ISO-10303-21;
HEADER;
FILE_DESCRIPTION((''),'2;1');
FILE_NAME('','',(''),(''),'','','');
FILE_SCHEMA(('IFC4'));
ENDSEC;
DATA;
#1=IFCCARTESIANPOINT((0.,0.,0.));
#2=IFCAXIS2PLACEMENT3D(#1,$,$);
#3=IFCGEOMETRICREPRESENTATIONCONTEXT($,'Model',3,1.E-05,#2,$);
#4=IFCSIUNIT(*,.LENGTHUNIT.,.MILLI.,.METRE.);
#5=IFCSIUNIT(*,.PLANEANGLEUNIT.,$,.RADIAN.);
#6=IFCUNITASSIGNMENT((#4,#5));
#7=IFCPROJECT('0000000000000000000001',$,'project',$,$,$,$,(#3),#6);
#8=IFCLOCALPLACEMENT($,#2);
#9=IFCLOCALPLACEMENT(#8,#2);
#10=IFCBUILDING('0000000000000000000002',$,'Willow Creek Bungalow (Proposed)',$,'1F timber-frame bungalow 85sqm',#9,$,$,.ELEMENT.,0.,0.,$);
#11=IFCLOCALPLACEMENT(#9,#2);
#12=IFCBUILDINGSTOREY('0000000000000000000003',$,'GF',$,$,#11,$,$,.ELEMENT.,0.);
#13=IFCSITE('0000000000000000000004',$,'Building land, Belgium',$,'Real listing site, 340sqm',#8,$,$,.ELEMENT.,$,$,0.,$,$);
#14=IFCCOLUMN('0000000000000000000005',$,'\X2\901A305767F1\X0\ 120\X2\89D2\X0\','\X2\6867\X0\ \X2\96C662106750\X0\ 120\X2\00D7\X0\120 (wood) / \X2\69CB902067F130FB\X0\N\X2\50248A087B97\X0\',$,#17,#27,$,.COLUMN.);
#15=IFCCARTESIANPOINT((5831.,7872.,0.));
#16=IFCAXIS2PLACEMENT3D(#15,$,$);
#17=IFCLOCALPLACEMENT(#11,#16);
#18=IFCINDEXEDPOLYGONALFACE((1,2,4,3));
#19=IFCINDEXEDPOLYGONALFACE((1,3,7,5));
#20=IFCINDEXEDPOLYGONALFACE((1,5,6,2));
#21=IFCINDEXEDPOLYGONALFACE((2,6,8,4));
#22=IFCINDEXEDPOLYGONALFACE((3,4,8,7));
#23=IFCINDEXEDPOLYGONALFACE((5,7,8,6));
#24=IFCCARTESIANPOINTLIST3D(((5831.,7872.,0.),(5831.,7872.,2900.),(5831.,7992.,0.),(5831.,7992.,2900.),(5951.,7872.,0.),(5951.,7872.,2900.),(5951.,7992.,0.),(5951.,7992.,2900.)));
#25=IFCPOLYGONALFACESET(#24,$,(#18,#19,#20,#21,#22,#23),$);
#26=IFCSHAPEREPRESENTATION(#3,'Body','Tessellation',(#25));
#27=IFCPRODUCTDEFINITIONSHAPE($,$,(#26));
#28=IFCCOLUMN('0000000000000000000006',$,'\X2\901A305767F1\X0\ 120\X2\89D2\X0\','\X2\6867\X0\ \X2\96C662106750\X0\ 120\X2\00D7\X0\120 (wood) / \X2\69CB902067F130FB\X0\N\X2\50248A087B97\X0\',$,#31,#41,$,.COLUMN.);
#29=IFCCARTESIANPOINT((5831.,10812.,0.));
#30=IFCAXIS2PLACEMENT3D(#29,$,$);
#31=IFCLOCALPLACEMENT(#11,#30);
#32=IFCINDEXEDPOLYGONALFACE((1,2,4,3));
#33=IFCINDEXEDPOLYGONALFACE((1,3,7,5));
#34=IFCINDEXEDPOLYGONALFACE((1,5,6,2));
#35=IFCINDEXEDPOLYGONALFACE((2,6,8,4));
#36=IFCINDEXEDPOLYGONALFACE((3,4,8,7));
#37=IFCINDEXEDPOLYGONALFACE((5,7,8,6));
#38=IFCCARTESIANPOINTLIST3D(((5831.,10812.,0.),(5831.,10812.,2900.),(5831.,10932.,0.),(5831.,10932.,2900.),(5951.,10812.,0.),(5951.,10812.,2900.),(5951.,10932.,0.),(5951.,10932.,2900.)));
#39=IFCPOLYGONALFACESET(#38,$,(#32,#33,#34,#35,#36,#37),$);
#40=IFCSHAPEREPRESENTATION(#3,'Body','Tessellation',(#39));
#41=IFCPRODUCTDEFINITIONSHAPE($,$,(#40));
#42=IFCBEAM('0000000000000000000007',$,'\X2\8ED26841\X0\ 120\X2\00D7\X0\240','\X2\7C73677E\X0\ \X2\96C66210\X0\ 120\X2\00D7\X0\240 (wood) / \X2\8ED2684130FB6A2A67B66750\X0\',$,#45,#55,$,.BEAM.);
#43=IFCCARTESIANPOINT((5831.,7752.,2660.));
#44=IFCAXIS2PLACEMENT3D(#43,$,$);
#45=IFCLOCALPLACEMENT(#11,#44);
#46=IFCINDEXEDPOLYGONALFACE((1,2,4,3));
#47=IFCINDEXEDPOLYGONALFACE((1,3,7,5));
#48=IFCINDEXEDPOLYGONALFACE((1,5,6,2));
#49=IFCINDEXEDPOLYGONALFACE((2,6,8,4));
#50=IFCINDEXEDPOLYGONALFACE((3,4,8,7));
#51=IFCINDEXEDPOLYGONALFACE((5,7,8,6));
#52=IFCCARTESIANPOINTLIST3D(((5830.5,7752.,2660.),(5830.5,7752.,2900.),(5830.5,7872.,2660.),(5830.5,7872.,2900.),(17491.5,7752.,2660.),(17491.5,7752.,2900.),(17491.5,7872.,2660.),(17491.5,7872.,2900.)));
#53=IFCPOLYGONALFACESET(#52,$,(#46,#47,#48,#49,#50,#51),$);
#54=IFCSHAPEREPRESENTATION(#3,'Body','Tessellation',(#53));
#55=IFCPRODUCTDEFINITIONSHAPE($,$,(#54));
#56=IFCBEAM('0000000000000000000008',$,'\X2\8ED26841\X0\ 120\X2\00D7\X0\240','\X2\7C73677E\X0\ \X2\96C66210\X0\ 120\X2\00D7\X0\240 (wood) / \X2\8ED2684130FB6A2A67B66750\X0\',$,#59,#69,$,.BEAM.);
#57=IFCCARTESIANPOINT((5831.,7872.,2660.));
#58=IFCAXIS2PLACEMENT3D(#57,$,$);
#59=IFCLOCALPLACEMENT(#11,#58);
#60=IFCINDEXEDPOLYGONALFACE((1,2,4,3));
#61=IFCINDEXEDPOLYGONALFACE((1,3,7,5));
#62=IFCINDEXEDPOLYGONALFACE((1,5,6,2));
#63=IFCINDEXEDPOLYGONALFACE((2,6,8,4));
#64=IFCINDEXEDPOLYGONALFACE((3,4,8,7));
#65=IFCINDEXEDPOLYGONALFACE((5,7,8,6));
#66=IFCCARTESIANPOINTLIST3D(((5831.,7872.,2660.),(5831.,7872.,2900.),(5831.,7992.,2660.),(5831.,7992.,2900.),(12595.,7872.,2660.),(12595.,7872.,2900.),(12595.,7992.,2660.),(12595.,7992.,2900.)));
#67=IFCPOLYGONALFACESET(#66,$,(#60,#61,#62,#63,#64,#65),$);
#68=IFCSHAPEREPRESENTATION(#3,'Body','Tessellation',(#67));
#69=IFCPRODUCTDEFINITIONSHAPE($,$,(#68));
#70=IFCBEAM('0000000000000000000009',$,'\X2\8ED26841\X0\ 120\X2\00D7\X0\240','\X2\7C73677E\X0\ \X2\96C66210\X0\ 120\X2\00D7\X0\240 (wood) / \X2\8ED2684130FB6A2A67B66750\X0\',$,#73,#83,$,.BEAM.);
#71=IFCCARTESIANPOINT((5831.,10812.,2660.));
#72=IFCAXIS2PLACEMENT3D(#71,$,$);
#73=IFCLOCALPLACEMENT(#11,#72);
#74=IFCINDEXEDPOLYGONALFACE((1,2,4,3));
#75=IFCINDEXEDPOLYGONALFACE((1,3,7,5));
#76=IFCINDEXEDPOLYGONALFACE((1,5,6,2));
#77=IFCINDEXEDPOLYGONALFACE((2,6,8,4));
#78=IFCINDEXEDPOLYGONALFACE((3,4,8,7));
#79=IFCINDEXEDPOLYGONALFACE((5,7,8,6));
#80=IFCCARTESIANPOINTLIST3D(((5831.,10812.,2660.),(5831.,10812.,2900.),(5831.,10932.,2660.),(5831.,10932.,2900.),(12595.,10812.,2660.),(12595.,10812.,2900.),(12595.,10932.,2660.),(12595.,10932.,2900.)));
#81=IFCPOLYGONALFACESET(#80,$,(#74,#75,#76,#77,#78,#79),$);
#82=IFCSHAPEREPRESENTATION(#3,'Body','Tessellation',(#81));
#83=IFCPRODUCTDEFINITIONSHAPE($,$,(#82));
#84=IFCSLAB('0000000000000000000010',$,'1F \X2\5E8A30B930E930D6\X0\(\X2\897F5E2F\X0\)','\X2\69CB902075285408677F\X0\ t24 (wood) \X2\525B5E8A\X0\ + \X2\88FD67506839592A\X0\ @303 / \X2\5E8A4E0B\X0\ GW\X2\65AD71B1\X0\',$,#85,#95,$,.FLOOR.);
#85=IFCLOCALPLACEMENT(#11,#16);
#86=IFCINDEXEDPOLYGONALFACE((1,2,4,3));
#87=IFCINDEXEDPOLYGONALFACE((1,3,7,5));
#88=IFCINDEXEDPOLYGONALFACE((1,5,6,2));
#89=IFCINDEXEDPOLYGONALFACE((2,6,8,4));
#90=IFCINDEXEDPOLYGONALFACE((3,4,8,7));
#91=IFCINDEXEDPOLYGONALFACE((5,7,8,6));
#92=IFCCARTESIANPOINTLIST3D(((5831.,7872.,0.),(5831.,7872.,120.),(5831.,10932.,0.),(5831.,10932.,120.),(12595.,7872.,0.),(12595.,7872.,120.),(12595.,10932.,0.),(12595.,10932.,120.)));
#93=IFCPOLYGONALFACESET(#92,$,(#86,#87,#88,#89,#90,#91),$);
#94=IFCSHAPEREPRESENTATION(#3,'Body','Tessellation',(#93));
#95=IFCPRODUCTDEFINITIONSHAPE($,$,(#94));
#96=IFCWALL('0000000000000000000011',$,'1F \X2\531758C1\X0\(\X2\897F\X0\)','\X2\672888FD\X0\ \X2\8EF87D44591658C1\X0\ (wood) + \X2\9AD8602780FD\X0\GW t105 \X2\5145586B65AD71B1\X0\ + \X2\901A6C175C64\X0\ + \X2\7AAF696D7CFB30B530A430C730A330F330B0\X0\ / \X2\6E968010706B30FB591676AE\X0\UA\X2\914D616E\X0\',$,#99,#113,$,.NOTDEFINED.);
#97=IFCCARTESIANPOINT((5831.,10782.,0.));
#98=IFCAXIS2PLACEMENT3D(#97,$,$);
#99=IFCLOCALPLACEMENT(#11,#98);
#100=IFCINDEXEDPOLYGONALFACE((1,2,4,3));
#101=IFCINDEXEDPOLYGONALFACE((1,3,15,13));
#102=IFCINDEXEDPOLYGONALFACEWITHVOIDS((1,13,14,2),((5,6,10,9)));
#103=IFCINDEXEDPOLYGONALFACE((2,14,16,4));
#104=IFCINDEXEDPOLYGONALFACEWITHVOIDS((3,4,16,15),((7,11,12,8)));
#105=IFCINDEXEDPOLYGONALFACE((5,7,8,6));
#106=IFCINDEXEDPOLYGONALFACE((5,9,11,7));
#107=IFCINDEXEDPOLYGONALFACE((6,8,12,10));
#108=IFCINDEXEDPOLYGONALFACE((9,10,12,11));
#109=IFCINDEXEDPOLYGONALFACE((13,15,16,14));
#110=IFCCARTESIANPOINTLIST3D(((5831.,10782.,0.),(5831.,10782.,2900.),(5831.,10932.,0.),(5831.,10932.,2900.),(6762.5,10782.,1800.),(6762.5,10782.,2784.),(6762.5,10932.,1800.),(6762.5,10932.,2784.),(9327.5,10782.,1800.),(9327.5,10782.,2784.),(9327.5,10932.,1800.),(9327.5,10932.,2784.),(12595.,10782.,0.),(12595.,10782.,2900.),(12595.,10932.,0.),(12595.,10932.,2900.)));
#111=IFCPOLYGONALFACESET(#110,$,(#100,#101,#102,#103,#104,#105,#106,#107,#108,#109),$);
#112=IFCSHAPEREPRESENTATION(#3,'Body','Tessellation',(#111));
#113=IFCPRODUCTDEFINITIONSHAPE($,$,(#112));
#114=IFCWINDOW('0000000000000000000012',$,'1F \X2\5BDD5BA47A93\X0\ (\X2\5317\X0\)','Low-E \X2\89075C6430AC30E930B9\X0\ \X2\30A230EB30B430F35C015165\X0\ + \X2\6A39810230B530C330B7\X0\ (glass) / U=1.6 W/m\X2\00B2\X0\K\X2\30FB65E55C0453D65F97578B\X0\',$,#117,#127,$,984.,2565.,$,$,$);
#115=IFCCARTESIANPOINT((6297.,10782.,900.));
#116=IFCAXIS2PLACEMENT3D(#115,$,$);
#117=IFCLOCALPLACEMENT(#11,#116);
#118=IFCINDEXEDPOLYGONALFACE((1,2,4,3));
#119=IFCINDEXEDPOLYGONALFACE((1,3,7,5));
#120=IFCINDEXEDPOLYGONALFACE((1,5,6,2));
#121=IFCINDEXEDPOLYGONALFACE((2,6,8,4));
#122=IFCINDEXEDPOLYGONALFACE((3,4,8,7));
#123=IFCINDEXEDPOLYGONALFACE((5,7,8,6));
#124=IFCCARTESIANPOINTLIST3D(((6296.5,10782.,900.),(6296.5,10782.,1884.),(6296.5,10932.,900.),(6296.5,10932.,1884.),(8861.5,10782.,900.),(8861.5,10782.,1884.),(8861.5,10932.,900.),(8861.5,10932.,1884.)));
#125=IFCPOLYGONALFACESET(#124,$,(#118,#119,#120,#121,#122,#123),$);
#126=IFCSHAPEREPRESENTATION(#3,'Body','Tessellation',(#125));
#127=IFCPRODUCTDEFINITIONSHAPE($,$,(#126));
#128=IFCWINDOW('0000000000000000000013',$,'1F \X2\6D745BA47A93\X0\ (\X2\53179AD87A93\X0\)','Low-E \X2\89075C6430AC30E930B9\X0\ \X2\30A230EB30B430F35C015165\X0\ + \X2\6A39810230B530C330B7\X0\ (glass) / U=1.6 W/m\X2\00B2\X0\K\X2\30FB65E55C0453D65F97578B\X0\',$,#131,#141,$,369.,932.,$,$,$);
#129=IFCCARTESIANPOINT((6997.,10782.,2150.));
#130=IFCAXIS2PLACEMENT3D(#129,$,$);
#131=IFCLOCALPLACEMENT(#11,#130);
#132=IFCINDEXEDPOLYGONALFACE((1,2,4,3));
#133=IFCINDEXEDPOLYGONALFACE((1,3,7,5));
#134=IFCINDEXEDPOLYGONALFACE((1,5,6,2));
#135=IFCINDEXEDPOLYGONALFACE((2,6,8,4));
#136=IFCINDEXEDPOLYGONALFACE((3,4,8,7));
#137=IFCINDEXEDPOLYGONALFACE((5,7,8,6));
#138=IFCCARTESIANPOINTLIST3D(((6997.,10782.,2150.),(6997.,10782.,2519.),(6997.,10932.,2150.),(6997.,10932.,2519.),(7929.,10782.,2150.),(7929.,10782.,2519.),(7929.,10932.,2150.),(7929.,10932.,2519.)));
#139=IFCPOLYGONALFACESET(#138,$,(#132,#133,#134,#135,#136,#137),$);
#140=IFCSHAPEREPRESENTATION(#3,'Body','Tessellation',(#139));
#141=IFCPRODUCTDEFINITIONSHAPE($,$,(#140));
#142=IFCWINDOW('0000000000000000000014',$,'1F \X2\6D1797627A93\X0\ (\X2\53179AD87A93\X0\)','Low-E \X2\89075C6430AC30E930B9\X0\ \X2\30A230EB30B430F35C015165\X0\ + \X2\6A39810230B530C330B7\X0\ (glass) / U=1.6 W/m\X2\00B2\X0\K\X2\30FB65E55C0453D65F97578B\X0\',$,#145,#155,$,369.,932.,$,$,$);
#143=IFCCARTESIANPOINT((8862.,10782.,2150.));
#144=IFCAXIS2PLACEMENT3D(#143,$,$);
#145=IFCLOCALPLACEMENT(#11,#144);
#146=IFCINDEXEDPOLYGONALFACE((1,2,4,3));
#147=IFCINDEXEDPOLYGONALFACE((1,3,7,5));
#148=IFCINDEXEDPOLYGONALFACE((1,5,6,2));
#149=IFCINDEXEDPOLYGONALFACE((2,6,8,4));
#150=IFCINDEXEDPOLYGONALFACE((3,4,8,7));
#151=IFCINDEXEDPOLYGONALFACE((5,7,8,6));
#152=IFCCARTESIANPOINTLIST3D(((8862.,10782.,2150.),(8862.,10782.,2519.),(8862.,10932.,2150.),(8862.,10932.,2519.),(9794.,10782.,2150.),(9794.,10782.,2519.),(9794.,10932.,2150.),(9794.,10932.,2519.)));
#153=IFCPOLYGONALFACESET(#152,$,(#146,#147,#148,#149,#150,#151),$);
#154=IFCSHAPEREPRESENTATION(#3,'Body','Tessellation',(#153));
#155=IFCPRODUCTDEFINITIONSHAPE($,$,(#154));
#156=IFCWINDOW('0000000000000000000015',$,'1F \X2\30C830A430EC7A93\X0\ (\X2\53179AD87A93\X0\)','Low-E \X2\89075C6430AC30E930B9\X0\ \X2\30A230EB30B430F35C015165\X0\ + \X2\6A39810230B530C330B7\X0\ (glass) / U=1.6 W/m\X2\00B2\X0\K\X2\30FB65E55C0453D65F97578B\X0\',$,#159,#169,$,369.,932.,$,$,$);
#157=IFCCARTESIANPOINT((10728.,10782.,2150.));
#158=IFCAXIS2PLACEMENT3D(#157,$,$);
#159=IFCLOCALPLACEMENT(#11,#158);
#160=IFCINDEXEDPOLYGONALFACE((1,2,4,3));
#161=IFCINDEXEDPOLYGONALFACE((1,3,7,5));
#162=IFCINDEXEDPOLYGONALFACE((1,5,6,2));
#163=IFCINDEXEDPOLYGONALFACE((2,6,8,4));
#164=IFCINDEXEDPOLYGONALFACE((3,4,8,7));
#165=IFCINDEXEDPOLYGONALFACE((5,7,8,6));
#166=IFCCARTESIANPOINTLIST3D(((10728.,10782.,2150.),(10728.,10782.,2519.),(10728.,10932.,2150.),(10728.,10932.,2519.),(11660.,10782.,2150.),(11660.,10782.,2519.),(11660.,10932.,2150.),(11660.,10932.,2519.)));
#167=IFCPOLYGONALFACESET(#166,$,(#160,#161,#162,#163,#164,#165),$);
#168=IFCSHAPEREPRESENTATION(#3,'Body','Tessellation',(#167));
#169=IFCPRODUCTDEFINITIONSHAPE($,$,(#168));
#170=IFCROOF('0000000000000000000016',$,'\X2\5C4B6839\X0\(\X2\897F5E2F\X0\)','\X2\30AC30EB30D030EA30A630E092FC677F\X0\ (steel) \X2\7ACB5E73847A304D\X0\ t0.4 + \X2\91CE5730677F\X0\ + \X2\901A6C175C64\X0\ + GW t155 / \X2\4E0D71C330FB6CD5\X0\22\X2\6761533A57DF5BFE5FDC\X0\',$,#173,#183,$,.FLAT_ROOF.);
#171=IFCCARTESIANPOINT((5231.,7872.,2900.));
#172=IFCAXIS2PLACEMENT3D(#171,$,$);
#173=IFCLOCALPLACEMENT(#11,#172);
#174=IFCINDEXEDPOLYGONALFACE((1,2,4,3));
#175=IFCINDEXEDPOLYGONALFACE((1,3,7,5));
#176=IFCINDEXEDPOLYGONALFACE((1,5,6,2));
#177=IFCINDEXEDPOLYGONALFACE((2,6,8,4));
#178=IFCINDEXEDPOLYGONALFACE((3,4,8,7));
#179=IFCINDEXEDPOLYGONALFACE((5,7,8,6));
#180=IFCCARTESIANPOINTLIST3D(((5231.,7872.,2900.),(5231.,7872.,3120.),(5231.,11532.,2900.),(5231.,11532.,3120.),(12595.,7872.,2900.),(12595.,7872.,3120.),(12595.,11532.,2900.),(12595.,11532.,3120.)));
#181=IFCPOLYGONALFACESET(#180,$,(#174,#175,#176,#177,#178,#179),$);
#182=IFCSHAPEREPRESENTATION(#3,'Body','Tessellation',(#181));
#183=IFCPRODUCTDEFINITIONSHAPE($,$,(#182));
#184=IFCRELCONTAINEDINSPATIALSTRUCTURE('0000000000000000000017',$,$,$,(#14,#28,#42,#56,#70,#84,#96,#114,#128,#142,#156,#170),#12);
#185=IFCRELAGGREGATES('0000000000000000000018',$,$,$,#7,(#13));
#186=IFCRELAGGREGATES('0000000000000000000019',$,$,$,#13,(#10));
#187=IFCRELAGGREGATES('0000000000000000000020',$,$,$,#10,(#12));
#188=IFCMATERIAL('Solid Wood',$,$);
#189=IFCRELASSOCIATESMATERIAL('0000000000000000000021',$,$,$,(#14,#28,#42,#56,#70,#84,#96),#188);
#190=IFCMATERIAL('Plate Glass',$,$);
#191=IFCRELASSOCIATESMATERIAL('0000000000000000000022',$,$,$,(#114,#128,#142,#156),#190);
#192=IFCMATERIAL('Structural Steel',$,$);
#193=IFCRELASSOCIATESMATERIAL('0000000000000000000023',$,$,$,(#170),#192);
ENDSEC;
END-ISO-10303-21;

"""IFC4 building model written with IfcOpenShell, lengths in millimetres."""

from ifc_helpers import new_model, si_unit, frame, frame_2d, origin, place, context, project, spatial, rectangle, extrude, material, element, fill, save


model = new_model("IFC4")

# Units and contexts
model_context = context("Model", 3, precision=1e-05, world=origin())
ifc_project = project(units=[si_unit("LENGTHUNIT", "METRE", prefix="MILLI"), si_unit("PLANEANGLEUNIT", "RADIAN")], contexts=[model_context])

# Site, building, storey
site_placement = place(None, origin())
site = spatial("IfcSite", under=ifc_project, at=site_placement, Name="Building land, Belgium", ObjectType="Real listing site, 340sqm", CompositionType="ELEMENT", RefElevation=0.0)
building_placement = place(site_placement, origin())
building = spatial("IfcBuilding", under=site, at=building_placement, Name="Willow Creek Bungalow (Proposed)", ObjectType="1F timber-frame bungalow 85sqm", CompositionType="ELEMENT", ElevationOfRefHeight=0.0, ElevationOfTerrain=0.0)
storey_placement = place(building_placement, origin())
storey = spatial("IfcBuildingStorey", under=building, at=storey_placement, Name="GF", CompositionType="ELEMENT", Elevation=0.0)

# Columns
ifc_material_1 = material(Name="Solid Wood")
column_1_placement = place(storey_placement, frame((5831.0, 7872.0, 0.0)))
element("IfcColumn", 1, at=column_1_placement, inside=storey, material=ifc_material_1, Name="通し柱 120角", Description="桧 集成材 120×120 (wood) / 構造柱・N値計算", PredefinedType="COLUMN", context=model_context, shape_type="SweptSolid", body=[
    extrude(rectangle(XDim=120.0, YDim=120.0, at=frame_2d((60.0, 60.0))), frame((5831.0, 7872.0, 0.0)), (0.0, 0.0, 1.0), 2900.0),
])
column_2_placement = place(storey_placement, frame((5831.0, 10812.0, 0.0)))
element("IfcColumn", 2, at=column_2_placement, inside=storey, material=ifc_material_1, Name="通し柱 120角", Description="桧 集成材 120×120 (wood) / 構造柱・N値計算", PredefinedType="COLUMN", context=model_context, shape_type="SweptSolid", body=[
    extrude(rectangle(XDim=120.0, YDim=120.0, at=frame_2d((60.0, 60.0))), frame((5831.0, 10812.0, 0.0)), (0.0, 0.0, 1.0), 2900.0),
])

# Beams
beam_1_placement = place(storey_placement, frame((5831.0, 7752.0, 2660.0)))
element("IfcBeam", 3, at=beam_1_placement, inside=storey, material=ifc_material_1, Name="軒桁 120×240", Description="米松 集成 120×240 (wood) / 軒桁・横架材", PredefinedType="BEAM", context=model_context, shape_type="SweptSolid", body=[
    extrude(rectangle(XDim=11661.0, YDim=120.0, at=frame_2d((5830.0, 60.0))), frame((5831.0, 7752.0, 2660.0)), (0.0, 0.0, 1.0), 240.0),
])
beam_2_placement = place(storey_placement, frame((5831.0, 7872.0, 2660.0)))
element("IfcBeam", 4, at=beam_2_placement, inside=storey, material=ifc_material_1, Name="軒桁 120×240", Description="米松 集成 120×240 (wood) / 軒桁・横架材", PredefinedType="BEAM", context=model_context, shape_type="SweptSolid", body=[
    extrude(rectangle(XDim=6764.0, YDim=120.0, at=frame_2d((3382.0, 60.0))), frame((5831.0, 7872.0, 2660.0)), (0.0, 0.0, 1.0), 240.0),
])
beam_3_placement = place(storey_placement, frame((5831.0, 10812.0, 2660.0)))
element("IfcBeam", 5, at=beam_3_placement, inside=storey, material=ifc_material_1, Name="軒桁 120×240", Description="米松 集成 120×240 (wood) / 軒桁・横架材", PredefinedType="BEAM", context=model_context, shape_type="SweptSolid", body=[
    extrude(rectangle(XDim=6764.0, YDim=120.0, at=frame_2d((3382.0, 60.0))), frame((5831.0, 10812.0, 2660.0)), (0.0, 0.0, 1.0), 240.0),
])

# Slab
slab_placement = place(storey_placement, frame((5831.0, 7872.0, 0.0)))
element("IfcSlab", 6, at=slab_placement, inside=storey, material=ifc_material_1, Name="1F 床スラブ(西帯)", Description="構造用合板 t24 (wood) 剛床 + 製材根太 @303 / 床下 GW断熱", PredefinedType="FLOOR", context=model_context, shape_type="SweptSolid", body=[
    extrude(rectangle(XDim=6764.0, YDim=3060.0, at=frame_2d((3382.0, 1530.0))), frame((5831.0, 7872.0, 0.0)), (0.0, 0.0, 1.0), 120.0),
])

# Wall, openings, windows
wall_1_placement = place(storey_placement, frame((5831.0, 10782.0, 0.0)))
wall_1 = element("IfcWall", 7, at=wall_1_placement, inside=storey, material=ifc_material_1, Name="1F 北壁(西)", Description="木製 軸組外壁 (wood) + 高性能GW t105 充填断熱 + 通気層 + 窯業系サイディング / 準耐火・外皮UA配慮", PredefinedType="NOTDEFINED", context=model_context, shape_type="SweptSolid", body=[
    extrude(rectangle(XDim=6764.0, YDim=150.0, at=frame_2d((3382.0, 75.0))), frame((5831.0, 10782.0, 0.0)), (0.0, 0.0, 1.0), 2900.0),
])
opening_1_placement = place(storey_placement, frame((6297.0, 10782.0, 900.0)))
opening_1 = element("IfcOpeningElement", 8, at=opening_1_placement, cuts=wall_1, PredefinedType="NOTDEFINED", context=model_context, shape_type="SweptSolid", body=[
    extrude(rectangle(XDim=2565.0, YDim=150.0, at=frame_2d((1282.0, 75.0))), frame((6297.0, 10782.0, 900.0)), (0.0, 0.0, 1.0), 984.0),
])
opening_2_placement = place(storey_placement, frame((6997.0, 10782.0, 2150.0)))
opening_2 = element("IfcOpeningElement", 9, at=opening_2_placement, cuts=wall_1, PredefinedType="NOTDEFINED", context=model_context, shape_type="SweptSolid", body=[
    extrude(rectangle(XDim=932.0, YDim=150.0, at=frame_2d((466.0, 75.0))), frame((6997.0, 10782.0, 2150.0)), (0.0, 0.0, 1.0), 369.0),
])
opening_3_placement = place(storey_placement, frame((8862.0, 10782.0, 2150.0)))
opening_3 = element("IfcOpeningElement", 10, at=opening_3_placement, cuts=wall_1, PredefinedType="NOTDEFINED", context=model_context, shape_type="SweptSolid", body=[
    extrude(rectangle(XDim=932.0, YDim=150.0, at=frame_2d((466.0, 75.0))), frame((8862.0, 10782.0, 2150.0)), (0.0, 0.0, 1.0), 369.0),
])
opening_4_placement = place(storey_placement, frame((10728.0, 10782.0, 2150.0)))
opening_4 = element("IfcOpeningElement", 11, at=opening_4_placement, cuts=wall_1, PredefinedType="NOTDEFINED", context=model_context, shape_type="SweptSolid", body=[
    extrude(rectangle(XDim=932.0, YDim=150.0, at=frame_2d((466.0, 75.0))), frame((10728.0, 10782.0, 2150.0)), (0.0, 0.0, 1.0), 369.0),
])
ifc_material_2 = material(Name="Plate Glass")
window_1_placement = place(storey_placement, frame((6297.0, 10782.0, 900.0)))
window_1 = element("IfcWindow", 12, at=window_1_placement, inside=storey, material=ifc_material_2, Name="1F 寝室窓 (北)", Description="Low-E 複層ガラス アルゴン封入 + 樹脂サッシ (glass) / U=1.6 W/m²K・日射取得型", OverallHeight=984.0, OverallWidth=2565.0, context=model_context, shape_type="SweptSolid", body=[
    extrude(rectangle(XDim=2565.0, YDim=150.0, at=frame_2d((1282.0, 75.0))), frame((6297.0, 10782.0, 900.0)), (0.0, 0.0, 1.0), 984.0),
])
fill(opening_1, window_1)
window_2_placement = place(storey_placement, frame((6997.0, 10782.0, 2150.0)))
window_2 = element("IfcWindow", 13, at=window_2_placement, inside=storey, material=ifc_material_2, Name="1F 浴室窓 (北高窓)", Description="Low-E 複層ガラス アルゴン封入 + 樹脂サッシ (glass) / U=1.6 W/m²K・日射取得型", OverallHeight=369.0, OverallWidth=932.0, context=model_context, shape_type="SweptSolid", body=[
    extrude(rectangle(XDim=932.0, YDim=150.0, at=frame_2d((466.0, 75.0))), frame((6997.0, 10782.0, 2150.0)), (0.0, 0.0, 1.0), 369.0),
])
fill(opening_2, window_2)
window_3_placement = place(storey_placement, frame((8862.0, 10782.0, 2150.0)))
window_3 = element("IfcWindow", 14, at=window_3_placement, inside=storey, material=ifc_material_2, Name="1F 洗面窓 (北高窓)", Description="Low-E 複層ガラス アルゴン封入 + 樹脂サッシ (glass) / U=1.6 W/m²K・日射取得型", OverallHeight=369.0, OverallWidth=932.0, context=model_context, shape_type="SweptSolid", body=[
    extrude(rectangle(XDim=932.0, YDim=150.0, at=frame_2d((466.0, 75.0))), frame((8862.0, 10782.0, 2150.0)), (0.0, 0.0, 1.0), 369.0),
])
fill(opening_3, window_3)
window_4_placement = place(storey_placement, frame((10728.0, 10782.0, 2150.0)))
window_4 = element("IfcWindow", 15, at=window_4_placement, inside=storey, material=ifc_material_2, Name="1F トイレ窓 (北高窓)", Description="Low-E 複層ガラス アルゴン封入 + 樹脂サッシ (glass) / U=1.6 W/m²K・日射取得型", OverallHeight=369.0, OverallWidth=932.0, context=model_context, shape_type="SweptSolid", body=[
    extrude(rectangle(XDim=932.0, YDim=150.0, at=frame_2d((466.0, 75.0))), frame((10728.0, 10782.0, 2150.0)), (0.0, 0.0, 1.0), 369.0),
])
fill(opening_4, window_4)

# Roof
ifc_material_3 = material(Name="Structural Steel")
roof_placement = place(storey_placement, frame((5231.0, 7872.0, 2900.0)))
element("IfcRoof", 16, at=roof_placement, inside=storey, material=ifc_material_3, Name="屋根(西帯)", Description="ガルバリウム鋼板 (steel) 立平葺き t0.4 + 野地板 + 通気層 + GW t155 / 不燃・法22条区域対応", PredefinedType="FLAT_ROOF", context=model_context, shape_type="SweptSolid", body=[
    extrude(rectangle(XDim=7364.0, YDim=3660.0, at=frame_2d((3682.0, 1830.0))), frame((5231.0, 7872.0, 2900.0)), (0.0, 0.0, 1.0), 220.0),
])

save(model, "model.ifc")
